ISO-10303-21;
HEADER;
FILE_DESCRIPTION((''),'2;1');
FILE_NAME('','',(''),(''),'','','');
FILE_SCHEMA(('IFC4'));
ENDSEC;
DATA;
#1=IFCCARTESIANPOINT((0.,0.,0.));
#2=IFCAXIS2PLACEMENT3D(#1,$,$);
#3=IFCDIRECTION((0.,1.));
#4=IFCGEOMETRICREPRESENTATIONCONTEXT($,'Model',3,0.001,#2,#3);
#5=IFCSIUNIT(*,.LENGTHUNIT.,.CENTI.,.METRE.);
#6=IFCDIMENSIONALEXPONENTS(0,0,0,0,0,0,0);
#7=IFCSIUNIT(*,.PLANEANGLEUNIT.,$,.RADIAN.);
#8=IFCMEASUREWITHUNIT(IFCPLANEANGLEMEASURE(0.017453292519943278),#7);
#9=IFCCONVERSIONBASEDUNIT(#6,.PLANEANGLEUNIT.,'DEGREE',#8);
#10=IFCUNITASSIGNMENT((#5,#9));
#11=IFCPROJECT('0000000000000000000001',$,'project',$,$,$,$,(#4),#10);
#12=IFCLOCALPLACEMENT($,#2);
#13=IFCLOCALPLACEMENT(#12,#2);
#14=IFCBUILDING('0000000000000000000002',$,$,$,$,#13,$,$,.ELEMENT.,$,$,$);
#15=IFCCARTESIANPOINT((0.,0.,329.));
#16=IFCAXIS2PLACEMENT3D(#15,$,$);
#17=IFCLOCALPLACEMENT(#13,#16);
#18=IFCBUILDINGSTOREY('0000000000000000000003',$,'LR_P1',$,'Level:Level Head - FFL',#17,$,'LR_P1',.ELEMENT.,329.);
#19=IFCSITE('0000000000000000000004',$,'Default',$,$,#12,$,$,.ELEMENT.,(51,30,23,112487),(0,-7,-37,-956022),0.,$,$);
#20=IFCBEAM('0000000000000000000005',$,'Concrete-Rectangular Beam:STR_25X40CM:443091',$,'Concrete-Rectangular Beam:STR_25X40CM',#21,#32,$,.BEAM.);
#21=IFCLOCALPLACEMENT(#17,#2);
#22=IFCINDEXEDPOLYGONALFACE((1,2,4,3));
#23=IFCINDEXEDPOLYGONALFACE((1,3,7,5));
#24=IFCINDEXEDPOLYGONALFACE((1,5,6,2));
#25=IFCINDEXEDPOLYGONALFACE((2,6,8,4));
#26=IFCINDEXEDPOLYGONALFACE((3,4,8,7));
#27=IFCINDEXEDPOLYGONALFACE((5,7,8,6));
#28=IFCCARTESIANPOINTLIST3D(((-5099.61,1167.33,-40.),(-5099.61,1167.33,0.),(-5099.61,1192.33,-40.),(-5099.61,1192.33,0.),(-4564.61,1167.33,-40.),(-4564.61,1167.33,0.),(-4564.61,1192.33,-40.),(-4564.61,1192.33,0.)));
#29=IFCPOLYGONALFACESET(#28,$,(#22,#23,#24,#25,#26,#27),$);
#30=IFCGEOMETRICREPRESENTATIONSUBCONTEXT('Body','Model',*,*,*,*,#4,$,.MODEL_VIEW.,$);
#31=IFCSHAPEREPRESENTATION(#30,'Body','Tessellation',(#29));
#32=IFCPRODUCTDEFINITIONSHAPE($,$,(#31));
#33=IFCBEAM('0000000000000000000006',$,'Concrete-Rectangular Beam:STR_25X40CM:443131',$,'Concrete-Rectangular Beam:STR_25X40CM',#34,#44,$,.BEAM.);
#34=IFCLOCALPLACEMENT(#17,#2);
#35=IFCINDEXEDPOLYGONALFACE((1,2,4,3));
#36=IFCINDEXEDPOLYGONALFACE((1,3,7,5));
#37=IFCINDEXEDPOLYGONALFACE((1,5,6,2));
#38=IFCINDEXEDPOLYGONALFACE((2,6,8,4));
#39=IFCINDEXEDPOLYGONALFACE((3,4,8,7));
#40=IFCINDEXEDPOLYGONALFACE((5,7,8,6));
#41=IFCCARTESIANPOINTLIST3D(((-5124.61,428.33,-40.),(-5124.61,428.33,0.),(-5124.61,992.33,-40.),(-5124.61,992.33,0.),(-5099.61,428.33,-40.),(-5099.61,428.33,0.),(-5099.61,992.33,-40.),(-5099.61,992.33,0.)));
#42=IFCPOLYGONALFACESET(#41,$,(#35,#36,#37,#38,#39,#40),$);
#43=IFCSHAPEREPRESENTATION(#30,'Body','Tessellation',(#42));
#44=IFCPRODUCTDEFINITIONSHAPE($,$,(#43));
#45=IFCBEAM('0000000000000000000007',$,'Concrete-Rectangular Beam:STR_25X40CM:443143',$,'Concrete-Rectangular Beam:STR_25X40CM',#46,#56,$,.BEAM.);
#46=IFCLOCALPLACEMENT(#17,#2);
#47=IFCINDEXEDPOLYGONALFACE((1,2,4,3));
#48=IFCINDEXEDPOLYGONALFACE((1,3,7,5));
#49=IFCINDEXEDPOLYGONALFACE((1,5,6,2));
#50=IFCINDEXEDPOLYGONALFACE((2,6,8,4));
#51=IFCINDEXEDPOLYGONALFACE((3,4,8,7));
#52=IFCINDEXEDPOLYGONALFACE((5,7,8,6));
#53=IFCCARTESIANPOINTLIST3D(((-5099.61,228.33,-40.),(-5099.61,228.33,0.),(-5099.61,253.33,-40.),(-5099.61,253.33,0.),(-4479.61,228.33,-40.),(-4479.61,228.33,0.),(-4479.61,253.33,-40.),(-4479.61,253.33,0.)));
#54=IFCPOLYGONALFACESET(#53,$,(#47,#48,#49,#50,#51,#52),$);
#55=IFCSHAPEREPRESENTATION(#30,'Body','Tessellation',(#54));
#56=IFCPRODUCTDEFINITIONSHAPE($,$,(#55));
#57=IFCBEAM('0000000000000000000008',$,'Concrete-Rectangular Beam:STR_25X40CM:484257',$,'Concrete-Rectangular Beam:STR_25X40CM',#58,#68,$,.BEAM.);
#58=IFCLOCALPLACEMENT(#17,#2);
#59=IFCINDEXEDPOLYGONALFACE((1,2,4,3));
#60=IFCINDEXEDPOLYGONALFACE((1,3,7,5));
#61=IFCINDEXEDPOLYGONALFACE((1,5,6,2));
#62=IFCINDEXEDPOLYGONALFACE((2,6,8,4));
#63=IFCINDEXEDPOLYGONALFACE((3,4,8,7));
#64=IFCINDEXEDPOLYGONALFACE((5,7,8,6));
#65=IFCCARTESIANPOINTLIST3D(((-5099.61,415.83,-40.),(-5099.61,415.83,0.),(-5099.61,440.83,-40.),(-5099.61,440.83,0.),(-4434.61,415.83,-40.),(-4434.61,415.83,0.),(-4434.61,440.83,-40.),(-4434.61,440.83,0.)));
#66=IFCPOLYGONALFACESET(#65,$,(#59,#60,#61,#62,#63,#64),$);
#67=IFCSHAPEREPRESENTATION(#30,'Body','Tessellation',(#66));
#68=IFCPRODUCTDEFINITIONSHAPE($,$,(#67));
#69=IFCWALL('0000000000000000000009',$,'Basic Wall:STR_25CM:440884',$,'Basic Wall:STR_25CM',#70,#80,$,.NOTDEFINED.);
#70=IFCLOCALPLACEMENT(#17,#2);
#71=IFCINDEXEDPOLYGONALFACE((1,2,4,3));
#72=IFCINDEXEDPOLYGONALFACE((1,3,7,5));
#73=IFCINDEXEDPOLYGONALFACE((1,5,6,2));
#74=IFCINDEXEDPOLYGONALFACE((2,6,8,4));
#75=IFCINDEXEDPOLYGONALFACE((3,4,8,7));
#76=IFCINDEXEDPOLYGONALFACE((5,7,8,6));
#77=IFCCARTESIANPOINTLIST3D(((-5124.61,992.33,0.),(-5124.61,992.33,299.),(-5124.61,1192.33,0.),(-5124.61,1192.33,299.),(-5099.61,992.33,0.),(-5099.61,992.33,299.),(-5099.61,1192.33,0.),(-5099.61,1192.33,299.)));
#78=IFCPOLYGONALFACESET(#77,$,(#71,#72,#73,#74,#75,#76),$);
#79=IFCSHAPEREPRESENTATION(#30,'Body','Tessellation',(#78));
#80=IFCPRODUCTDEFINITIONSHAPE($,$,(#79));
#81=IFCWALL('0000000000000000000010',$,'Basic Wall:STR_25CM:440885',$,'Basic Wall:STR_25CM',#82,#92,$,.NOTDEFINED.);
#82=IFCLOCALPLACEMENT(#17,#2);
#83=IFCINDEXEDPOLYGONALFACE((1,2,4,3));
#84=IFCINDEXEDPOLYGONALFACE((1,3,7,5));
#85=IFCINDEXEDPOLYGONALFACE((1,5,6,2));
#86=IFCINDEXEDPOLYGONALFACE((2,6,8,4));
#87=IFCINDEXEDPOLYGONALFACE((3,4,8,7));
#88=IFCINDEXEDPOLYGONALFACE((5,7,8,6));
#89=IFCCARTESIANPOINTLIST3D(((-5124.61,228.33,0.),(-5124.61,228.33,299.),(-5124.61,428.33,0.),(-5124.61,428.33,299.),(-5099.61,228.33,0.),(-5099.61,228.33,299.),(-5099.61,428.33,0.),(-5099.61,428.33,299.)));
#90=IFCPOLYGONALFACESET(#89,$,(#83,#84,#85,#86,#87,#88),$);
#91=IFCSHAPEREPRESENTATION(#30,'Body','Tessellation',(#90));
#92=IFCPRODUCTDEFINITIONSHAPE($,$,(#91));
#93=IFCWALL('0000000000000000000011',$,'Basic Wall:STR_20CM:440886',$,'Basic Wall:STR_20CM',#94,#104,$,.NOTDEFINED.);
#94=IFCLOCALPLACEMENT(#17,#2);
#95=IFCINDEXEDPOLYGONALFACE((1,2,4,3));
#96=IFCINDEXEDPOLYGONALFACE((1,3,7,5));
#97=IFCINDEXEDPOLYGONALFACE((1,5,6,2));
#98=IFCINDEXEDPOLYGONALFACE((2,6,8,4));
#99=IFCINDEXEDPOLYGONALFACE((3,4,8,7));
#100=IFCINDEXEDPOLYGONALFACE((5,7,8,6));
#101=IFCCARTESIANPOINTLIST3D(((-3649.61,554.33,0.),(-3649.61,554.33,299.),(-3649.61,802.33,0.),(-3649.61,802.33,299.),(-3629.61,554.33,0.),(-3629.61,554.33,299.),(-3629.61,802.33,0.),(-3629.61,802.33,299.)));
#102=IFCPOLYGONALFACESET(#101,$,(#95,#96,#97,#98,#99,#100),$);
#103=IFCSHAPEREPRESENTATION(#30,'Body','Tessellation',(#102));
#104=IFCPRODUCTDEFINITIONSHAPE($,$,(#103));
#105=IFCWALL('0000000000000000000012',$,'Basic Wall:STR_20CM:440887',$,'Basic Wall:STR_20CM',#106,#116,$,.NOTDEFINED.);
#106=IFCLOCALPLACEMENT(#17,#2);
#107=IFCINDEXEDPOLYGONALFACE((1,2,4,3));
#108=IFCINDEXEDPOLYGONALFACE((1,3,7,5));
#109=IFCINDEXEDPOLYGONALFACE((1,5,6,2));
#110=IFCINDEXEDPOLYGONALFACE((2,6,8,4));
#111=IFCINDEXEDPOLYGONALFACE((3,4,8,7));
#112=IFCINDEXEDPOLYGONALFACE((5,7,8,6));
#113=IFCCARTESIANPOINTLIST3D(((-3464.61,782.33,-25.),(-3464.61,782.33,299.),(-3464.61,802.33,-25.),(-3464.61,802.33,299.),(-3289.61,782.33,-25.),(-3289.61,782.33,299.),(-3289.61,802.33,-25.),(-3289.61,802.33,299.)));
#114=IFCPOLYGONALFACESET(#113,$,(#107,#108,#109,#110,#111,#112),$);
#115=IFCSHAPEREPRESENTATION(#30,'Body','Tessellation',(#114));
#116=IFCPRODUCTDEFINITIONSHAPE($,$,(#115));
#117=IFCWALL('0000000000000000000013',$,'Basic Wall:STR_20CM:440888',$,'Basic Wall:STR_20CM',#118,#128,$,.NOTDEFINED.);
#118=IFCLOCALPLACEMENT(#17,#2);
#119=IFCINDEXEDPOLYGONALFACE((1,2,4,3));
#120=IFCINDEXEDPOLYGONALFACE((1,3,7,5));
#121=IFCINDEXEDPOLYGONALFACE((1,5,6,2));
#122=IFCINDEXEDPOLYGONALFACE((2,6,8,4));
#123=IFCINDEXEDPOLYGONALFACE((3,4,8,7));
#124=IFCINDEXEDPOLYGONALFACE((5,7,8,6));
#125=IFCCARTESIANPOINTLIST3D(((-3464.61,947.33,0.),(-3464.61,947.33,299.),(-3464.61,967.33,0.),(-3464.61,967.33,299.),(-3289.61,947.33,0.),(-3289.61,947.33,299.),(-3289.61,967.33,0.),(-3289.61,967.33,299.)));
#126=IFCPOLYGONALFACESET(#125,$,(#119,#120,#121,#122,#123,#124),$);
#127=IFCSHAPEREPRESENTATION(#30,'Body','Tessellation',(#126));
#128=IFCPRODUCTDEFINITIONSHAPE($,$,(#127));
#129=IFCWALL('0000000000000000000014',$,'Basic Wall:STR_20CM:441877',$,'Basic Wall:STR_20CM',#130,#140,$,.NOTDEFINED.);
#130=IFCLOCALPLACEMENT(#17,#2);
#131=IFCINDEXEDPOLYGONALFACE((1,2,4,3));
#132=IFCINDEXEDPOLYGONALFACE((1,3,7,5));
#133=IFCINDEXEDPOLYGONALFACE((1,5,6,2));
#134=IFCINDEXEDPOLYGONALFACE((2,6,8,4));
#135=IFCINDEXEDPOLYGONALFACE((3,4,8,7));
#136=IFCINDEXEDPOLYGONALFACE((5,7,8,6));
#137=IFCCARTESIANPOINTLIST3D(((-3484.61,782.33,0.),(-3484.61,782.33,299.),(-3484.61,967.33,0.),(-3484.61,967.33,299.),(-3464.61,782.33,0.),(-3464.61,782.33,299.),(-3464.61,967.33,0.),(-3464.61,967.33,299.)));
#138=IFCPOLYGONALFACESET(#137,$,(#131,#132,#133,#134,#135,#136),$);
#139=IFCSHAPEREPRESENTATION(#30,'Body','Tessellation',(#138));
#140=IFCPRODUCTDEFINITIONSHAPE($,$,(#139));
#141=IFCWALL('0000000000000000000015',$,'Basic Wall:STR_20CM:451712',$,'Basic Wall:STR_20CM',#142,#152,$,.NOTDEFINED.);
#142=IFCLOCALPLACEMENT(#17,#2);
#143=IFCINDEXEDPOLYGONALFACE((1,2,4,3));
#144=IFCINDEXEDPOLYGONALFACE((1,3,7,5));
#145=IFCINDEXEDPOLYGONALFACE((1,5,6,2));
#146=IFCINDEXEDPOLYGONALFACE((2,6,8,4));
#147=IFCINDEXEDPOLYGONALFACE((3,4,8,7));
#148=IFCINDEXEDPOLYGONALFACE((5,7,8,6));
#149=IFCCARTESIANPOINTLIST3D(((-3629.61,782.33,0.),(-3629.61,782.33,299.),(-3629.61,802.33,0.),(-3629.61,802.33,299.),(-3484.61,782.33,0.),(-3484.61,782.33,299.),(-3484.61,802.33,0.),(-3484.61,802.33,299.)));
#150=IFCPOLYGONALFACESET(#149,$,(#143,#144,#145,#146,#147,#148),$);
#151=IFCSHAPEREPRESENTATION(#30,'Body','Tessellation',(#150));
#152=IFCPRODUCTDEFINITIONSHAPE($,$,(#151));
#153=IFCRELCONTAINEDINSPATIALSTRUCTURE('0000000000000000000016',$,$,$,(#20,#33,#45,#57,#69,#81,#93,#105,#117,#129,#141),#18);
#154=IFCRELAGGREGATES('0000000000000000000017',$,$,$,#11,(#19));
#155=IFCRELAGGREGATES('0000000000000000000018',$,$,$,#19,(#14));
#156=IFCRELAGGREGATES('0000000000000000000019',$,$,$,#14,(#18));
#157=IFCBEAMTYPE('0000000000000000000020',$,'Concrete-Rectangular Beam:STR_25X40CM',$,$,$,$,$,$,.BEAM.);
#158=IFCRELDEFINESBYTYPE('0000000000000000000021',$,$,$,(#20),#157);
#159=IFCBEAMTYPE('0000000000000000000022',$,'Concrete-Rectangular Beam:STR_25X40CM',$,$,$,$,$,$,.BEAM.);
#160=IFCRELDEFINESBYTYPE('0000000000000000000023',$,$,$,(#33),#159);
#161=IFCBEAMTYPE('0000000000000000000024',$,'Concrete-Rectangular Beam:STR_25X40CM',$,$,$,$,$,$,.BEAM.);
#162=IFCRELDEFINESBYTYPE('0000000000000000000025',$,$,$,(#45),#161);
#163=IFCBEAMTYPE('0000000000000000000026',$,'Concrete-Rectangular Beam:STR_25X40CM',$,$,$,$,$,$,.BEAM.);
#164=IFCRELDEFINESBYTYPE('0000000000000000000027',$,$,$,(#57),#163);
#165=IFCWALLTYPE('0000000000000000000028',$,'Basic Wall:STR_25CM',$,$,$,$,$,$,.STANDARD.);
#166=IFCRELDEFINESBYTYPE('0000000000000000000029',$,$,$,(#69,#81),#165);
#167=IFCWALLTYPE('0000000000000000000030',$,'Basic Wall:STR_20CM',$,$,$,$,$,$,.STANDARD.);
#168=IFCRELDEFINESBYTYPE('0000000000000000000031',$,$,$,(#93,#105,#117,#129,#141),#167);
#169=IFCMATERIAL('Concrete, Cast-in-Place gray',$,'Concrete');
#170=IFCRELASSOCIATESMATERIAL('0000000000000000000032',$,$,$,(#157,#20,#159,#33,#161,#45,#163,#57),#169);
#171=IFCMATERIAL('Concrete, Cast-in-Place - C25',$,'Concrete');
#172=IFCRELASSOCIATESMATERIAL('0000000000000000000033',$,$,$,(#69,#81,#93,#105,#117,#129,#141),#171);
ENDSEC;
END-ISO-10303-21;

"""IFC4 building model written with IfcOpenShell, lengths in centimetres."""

from ifc_helpers import new_model, entity, si_unit, converted_unit, direction, frame, origin, place, context, subcontext, project, spatial, indexed_curve, outline, extrude, source, transform, mapped, material, type_object, type_shapes, element, save


model = new_model("IFC4")

# Units and contexts
model_context = context("Model", 3, precision=0.001, world=origin(), true_north=direction((0.0, 1.0)))
body_context = subcontext(model_context, "Body", "Model", "MODEL_VIEW")
ifc_project = project(units=[si_unit("LENGTHUNIT", "METRE", prefix="CENTI"), converted_unit("PLANEANGLEUNIT", "DEGREE", entity("IfcPlaneAngleMeasure", 0.017453292519943278), si_unit("PLANEANGLEUNIT", "RADIAN"), dimensions=[0, 0, 0, 0, 0, 0, 0])], contexts=[model_context])

# Site, building, storey
site_placement = place(None, origin())
site = spatial("IfcSite", under=ifc_project, at=site_placement, Name="Default", CompositionType="ELEMENT", RefLatitude=(51, 30, 23, 112487), RefLongitude=(0, -7, -37, -956022), RefElevation=0.0)
building_placement = place(site_placement, origin())
building = spatial("IfcBuilding", under=site, at=building_placement, CompositionType="ELEMENT")
storey_placement = place(building_placement, frame((0.0, 0.0, 329.0)))
storey = spatial("IfcBuildingStorey", under=building, at=storey_placement, Name="LR_P1", ObjectType="Level:Level Head - FFL", LongName="LR_P1", CompositionType="ELEMENT", Elevation=329.0)

# Shared definitions
ifc_material_1 = material(Name="Concrete, Cast-in-Place gray", Category="Concrete")

# Beams
beam_type_1 = type_object("IfcBeamType", Name="Concrete-Rectangular Beam:STR_25X40CM", PredefinedType="BEAM", material=ifc_material_1)
shared_shape_1 = source(origin(), body_context, "Body", "SweptSolid", [
    extrude(outline(indexed_curve([(-20.0, -12.5), (20.0, -12.5), (20.0, 12.5), (-20.0, 12.5), (-20.0, -12.5)], self_intersect=False)), frame((-5099.61, 1179.83, 309.0), z_axis=(1.0, 0.0, 0.0), x_axis=(0.0, 0.0, -1.0)), (0.0, 0.0, 1.0), 535.0),
])
type_shapes(beam_type_1, [shared_shape_1])
beam_1_placement = place(storey_placement, frame((0.0, 0.0, -329.0)))
element("IfcBeam", 1, at=beam_1_placement, inside=storey, type_object=beam_type_1, material=ifc_material_1, Name="Concrete-Rectangular Beam:STR_25X40CM:443091", ObjectType="Concrete-Rectangular Beam:STR_25X40CM", PredefinedType="BEAM", context=body_context, shape_type="MappedRepresentation", body=[
    mapped(shared_shape_1, transform((0.0, 0.0, 0.0), scale=1.0)),
])
beam_type_2 = type_object("IfcBeamType", Name="Concrete-Rectangular Beam:STR_25X40CM", PredefinedType="BEAM", material=ifc_material_1)
shared_shape_2 = source(origin(), body_context, "Body", "SweptSolid", [
    extrude(outline(indexed_curve([(-12.5, -20.0), (12.5, -20.0), (12.5, 20.0), (-12.5, 20.0), (-12.5, -20.0)], self_intersect=False)), frame((-5112.11, 428.33, 309.0), z_axis=(0.0, 1.0, 0.0), x_axis=(-1.0, 0.0, 0.0)), (0.0, 0.0, 1.0), 564.0),
])
type_shapes(beam_type_2, [shared_shape_2])
beam_2_placement = place(storey_placement, frame((0.0, 0.0, -329.0)))
element("IfcBeam", 2, at=beam_2_placement, inside=storey, type_object=beam_type_2, material=ifc_material_1, Name="Concrete-Rectangular Beam:STR_25X40CM:443131", ObjectType="Concrete-Rectangular Beam:STR_25X40CM", PredefinedType="BEAM", context=body_context, shape_type="MappedRepresentation", body=[
    mapped(shared_shape_2, transform((0.0, 0.0, 0.0), scale=1.0)),
])
beam_type_3 = type_object("IfcBeamType", Name="Concrete-Rectangular Beam:STR_25X40CM", PredefinedType="BEAM", material=ifc_material_1)
shared_shape_3 = source(origin(), body_context, "Body", "SweptSolid", [
    extrude(outline(indexed_curve([(-20.0, -12.5), (20.0, -12.5), (20.0, 12.5), (-20.0, 12.5), (-20.0, -12.5)], self_intersect=False)), frame((-4479.61, 240.83, 309.0), z_axis=(-1.0, 0.0, 0.0), x_axis=(0.0, 0.0, -1.0)), (0.0, 0.0, 1.0), 620.0),
])
type_shapes(beam_type_3, [shared_shape_3])
beam_3_placement = place(storey_placement, frame((0.0, 0.0, -329.0)))
element("IfcBeam", 3, at=beam_3_placement, inside=storey, type_object=beam_type_3, material=ifc_material_1, Name="Concrete-Rectangular Beam:STR_25X40CM:443143", ObjectType="Concrete-Rectangular Beam:STR_25X40CM", PredefinedType="BEAM", context=body_context, shape_type="MappedRepresentation", body=[
    mapped(shared_shape_3, transform((0.0, 0.0, 0.0), scale=1.0)),
])
beam_type_4 = type_object("IfcBeamType", Name="Concrete-Rectangular Beam:STR_25X40CM", PredefinedType="BEAM", material=ifc_material_1)
shared_shape_4 = source(origin(), body_context, "Body", "SweptSolid", [
    extrude(outline(indexed_curve([(-20.0, -12.5), (20.0, -12.5), (20.0, 12.5), (-20.0, 12.5), (-20.0, -12.5)], self_intersect=False)), frame((-5099.61, 428.33, 309.0), z_axis=(1.0, 0.0, 0.0), x_axis=(0.0, 0.0, -1.0)), (0.0, 0.0, 1.0), 665.0),
])
type_shapes(beam_type_4, [shared_shape_4])
beam_4_placement = place(storey_placement, frame((0.0, 0.0, -329.0)))
element("IfcBeam", 4, at=beam_4_placement, inside=storey, type_object=beam_type_4, material=ifc_material_1, Name="Concrete-Rectangular Beam:STR_25X40CM:484257", ObjectType="Concrete-Rectangular Beam:STR_25X40CM", PredefinedType="BEAM", context=body_context, shape_type="MappedRepresentation", body=[
    mapped(shared_shape_4, transform((0.0, 0.0, 0.0), scale=1.0)),
])

# Walls
ifc_material_2 = material(Name="Concrete, Cast-in-Place - C25", Category="Concrete")
wall_type_1 = type_object("IfcWallType", Name="Basic Wall:STR_25CM", PredefinedType="STANDARD")
wall_1_placement = place(storey_placement, frame((-5112.11, 992.33, 0.0), z_axis=(0.0, 0.0, 1.0), x_axis=(0.0, 1.0, 0.0)))
element("IfcWall", 5, at=wall_1_placement, inside=storey, type_object=wall_type_1, material=ifc_material_2, Name="Basic Wall:STR_25CM:440884", ObjectType="Basic Wall:STR_25CM", PredefinedType="NOTDEFINED", context=body_context, shape_type="SweptSolid", body=[
    extrude(outline(indexed_curve([(200.0, 12.5), (0.0, 12.5), (0.0, -12.5), (200.0, -12.5), (200.0, 12.5)], self_intersect=False)), origin(), (0.0, 0.0, 1.0), 299.0),
])
wall_2_placement = place(storey_placement, frame((-5112.11, 228.33, 0.0), z_axis=(0.0, 0.0, 1.0), x_axis=(0.0, 1.0, 0.0)))
element("IfcWall", 6, at=wall_2_placement, inside=storey, type_object=wall_type_1, material=ifc_material_2, Name="Basic Wall:STR_25CM:440885", ObjectType="Basic Wall:STR_25CM", PredefinedType="NOTDEFINED", context=body_context, shape_type="SweptSolid", body=[
    extrude(outline(indexed_curve([(200.0, 12.5), (0.0, 12.5), (0.0, -12.5), (200.0, -12.5), (200.0, 12.5)], self_intersect=False)), origin(), (0.0, 0.0, 1.0), 299.0),
])
wall_type_2 = type_object("IfcWallType", Name="Basic Wall:STR_20CM", PredefinedType="STANDARD")
wall_3_placement = place(storey_placement, frame((-3639.61, 554.33, 0.0), z_axis=(0.0, 0.0, 1.0), x_axis=(0.0, 1.0, 0.0)))
element("IfcWall", 7, at=wall_3_placement, inside=storey, type_object=wall_type_2, material=ifc_material_2, Name="Basic Wall:STR_20CM:440886", ObjectType="Basic Wall:STR_20CM", PredefinedType="NOTDEFINED", context=body_context, shape_type="SweptSolid", body=[
    extrude(outline(indexed_curve([(248.0, 10.0), (0.0, 10.0), (0.0, -10.0), (248.0, -10.0), (248.0, 10.0)], self_intersect=False)), origin(), (0.0, 0.0, 1.0), 299.0),
])
wall_4_placement = place(storey_placement, frame((-3289.61, 792.33, -25.0), z_axis=(0.0, 0.0, 1.0), x_axis=(-1.0, 0.0, 0.0)))
element("IfcWall", 8, at=wall_4_placement, inside=storey, type_object=wall_type_2, material=ifc_material_2, Name="Basic Wall:STR_20CM:440887", ObjectType="Basic Wall:STR_20CM", PredefinedType="NOTDEFINED", context=body_context, shape_type="SweptSolid", body=[
    extrude(outline(indexed_curve([(175.0, 10.0), (0.0, 10.0), (0.0, -10.0), (175.0, -10.0), (175.0, 10.0)], self_intersect=False)), origin(), (0.0, 0.0, 1.0), 324.0),
])
wall_5_placement = place(storey_placement, frame((-3464.61, 957.33, 0.0)))
element("IfcWall", 9, at=wall_5_placement, inside=storey, type_object=wall_type_2, material=ifc_material_2, Name="Basic Wall:STR_20CM:440888", ObjectType="Basic Wall:STR_20CM", PredefinedType="NOTDEFINED", context=body_context, shape_type="SweptSolid", body=[
    extrude(outline(indexed_curve([(175.0, 10.0), (0.0, 10.0), (0.0, -10.0), (175.0, -10.0), (175.0, 10.0)], self_intersect=False)), origin(), (0.0, 0.0, 1.0), 299.0),
])
wall_6_placement = place(storey_placement, frame((-3474.61, 782.33, 0.0), z_axis=(0.0, 0.0, 1.0), x_axis=(0.0, 1.0, 0.0)))
element("IfcWall", 10, at=wall_6_placement, inside=storey, type_object=wall_type_2, material=ifc_material_2, Name="Basic Wall:STR_20CM:441877", ObjectType="Basic Wall:STR_20CM", PredefinedType="NOTDEFINED", context=body_context, shape_type="SweptSolid", body=[
    extrude(outline(indexed_curve([(185.0, 10.0), (0.0, 10.0), (0.0, -10.0), (185.0, -10.0), (185.0, 10.0)], self_intersect=False)), origin(), (0.0, 0.0, 1.0), 299.0),
])
wall_7_placement = place(storey_placement, frame((-3484.61, 792.33, 0.0), z_axis=(0.0, 0.0, 1.0), x_axis=(-1.0, 0.0, 0.0)))
element("IfcWall", 11, at=wall_7_placement, inside=storey, type_object=wall_type_2, material=ifc_material_2, Name="Basic Wall:STR_20CM:451712", ObjectType="Basic Wall:STR_20CM", PredefinedType="NOTDEFINED", context=body_context, shape_type="SweptSolid", body=[
    extrude(outline(indexed_curve([(145.0, 10.0), (0.0, 10.0), (0.0, -10.0), (145.0, -10.0), (145.0, 10.0)], self_intersect=False)), origin(), (0.0, 0.0, 1.0), 299.0),
])

save(model, "model.ifc")
